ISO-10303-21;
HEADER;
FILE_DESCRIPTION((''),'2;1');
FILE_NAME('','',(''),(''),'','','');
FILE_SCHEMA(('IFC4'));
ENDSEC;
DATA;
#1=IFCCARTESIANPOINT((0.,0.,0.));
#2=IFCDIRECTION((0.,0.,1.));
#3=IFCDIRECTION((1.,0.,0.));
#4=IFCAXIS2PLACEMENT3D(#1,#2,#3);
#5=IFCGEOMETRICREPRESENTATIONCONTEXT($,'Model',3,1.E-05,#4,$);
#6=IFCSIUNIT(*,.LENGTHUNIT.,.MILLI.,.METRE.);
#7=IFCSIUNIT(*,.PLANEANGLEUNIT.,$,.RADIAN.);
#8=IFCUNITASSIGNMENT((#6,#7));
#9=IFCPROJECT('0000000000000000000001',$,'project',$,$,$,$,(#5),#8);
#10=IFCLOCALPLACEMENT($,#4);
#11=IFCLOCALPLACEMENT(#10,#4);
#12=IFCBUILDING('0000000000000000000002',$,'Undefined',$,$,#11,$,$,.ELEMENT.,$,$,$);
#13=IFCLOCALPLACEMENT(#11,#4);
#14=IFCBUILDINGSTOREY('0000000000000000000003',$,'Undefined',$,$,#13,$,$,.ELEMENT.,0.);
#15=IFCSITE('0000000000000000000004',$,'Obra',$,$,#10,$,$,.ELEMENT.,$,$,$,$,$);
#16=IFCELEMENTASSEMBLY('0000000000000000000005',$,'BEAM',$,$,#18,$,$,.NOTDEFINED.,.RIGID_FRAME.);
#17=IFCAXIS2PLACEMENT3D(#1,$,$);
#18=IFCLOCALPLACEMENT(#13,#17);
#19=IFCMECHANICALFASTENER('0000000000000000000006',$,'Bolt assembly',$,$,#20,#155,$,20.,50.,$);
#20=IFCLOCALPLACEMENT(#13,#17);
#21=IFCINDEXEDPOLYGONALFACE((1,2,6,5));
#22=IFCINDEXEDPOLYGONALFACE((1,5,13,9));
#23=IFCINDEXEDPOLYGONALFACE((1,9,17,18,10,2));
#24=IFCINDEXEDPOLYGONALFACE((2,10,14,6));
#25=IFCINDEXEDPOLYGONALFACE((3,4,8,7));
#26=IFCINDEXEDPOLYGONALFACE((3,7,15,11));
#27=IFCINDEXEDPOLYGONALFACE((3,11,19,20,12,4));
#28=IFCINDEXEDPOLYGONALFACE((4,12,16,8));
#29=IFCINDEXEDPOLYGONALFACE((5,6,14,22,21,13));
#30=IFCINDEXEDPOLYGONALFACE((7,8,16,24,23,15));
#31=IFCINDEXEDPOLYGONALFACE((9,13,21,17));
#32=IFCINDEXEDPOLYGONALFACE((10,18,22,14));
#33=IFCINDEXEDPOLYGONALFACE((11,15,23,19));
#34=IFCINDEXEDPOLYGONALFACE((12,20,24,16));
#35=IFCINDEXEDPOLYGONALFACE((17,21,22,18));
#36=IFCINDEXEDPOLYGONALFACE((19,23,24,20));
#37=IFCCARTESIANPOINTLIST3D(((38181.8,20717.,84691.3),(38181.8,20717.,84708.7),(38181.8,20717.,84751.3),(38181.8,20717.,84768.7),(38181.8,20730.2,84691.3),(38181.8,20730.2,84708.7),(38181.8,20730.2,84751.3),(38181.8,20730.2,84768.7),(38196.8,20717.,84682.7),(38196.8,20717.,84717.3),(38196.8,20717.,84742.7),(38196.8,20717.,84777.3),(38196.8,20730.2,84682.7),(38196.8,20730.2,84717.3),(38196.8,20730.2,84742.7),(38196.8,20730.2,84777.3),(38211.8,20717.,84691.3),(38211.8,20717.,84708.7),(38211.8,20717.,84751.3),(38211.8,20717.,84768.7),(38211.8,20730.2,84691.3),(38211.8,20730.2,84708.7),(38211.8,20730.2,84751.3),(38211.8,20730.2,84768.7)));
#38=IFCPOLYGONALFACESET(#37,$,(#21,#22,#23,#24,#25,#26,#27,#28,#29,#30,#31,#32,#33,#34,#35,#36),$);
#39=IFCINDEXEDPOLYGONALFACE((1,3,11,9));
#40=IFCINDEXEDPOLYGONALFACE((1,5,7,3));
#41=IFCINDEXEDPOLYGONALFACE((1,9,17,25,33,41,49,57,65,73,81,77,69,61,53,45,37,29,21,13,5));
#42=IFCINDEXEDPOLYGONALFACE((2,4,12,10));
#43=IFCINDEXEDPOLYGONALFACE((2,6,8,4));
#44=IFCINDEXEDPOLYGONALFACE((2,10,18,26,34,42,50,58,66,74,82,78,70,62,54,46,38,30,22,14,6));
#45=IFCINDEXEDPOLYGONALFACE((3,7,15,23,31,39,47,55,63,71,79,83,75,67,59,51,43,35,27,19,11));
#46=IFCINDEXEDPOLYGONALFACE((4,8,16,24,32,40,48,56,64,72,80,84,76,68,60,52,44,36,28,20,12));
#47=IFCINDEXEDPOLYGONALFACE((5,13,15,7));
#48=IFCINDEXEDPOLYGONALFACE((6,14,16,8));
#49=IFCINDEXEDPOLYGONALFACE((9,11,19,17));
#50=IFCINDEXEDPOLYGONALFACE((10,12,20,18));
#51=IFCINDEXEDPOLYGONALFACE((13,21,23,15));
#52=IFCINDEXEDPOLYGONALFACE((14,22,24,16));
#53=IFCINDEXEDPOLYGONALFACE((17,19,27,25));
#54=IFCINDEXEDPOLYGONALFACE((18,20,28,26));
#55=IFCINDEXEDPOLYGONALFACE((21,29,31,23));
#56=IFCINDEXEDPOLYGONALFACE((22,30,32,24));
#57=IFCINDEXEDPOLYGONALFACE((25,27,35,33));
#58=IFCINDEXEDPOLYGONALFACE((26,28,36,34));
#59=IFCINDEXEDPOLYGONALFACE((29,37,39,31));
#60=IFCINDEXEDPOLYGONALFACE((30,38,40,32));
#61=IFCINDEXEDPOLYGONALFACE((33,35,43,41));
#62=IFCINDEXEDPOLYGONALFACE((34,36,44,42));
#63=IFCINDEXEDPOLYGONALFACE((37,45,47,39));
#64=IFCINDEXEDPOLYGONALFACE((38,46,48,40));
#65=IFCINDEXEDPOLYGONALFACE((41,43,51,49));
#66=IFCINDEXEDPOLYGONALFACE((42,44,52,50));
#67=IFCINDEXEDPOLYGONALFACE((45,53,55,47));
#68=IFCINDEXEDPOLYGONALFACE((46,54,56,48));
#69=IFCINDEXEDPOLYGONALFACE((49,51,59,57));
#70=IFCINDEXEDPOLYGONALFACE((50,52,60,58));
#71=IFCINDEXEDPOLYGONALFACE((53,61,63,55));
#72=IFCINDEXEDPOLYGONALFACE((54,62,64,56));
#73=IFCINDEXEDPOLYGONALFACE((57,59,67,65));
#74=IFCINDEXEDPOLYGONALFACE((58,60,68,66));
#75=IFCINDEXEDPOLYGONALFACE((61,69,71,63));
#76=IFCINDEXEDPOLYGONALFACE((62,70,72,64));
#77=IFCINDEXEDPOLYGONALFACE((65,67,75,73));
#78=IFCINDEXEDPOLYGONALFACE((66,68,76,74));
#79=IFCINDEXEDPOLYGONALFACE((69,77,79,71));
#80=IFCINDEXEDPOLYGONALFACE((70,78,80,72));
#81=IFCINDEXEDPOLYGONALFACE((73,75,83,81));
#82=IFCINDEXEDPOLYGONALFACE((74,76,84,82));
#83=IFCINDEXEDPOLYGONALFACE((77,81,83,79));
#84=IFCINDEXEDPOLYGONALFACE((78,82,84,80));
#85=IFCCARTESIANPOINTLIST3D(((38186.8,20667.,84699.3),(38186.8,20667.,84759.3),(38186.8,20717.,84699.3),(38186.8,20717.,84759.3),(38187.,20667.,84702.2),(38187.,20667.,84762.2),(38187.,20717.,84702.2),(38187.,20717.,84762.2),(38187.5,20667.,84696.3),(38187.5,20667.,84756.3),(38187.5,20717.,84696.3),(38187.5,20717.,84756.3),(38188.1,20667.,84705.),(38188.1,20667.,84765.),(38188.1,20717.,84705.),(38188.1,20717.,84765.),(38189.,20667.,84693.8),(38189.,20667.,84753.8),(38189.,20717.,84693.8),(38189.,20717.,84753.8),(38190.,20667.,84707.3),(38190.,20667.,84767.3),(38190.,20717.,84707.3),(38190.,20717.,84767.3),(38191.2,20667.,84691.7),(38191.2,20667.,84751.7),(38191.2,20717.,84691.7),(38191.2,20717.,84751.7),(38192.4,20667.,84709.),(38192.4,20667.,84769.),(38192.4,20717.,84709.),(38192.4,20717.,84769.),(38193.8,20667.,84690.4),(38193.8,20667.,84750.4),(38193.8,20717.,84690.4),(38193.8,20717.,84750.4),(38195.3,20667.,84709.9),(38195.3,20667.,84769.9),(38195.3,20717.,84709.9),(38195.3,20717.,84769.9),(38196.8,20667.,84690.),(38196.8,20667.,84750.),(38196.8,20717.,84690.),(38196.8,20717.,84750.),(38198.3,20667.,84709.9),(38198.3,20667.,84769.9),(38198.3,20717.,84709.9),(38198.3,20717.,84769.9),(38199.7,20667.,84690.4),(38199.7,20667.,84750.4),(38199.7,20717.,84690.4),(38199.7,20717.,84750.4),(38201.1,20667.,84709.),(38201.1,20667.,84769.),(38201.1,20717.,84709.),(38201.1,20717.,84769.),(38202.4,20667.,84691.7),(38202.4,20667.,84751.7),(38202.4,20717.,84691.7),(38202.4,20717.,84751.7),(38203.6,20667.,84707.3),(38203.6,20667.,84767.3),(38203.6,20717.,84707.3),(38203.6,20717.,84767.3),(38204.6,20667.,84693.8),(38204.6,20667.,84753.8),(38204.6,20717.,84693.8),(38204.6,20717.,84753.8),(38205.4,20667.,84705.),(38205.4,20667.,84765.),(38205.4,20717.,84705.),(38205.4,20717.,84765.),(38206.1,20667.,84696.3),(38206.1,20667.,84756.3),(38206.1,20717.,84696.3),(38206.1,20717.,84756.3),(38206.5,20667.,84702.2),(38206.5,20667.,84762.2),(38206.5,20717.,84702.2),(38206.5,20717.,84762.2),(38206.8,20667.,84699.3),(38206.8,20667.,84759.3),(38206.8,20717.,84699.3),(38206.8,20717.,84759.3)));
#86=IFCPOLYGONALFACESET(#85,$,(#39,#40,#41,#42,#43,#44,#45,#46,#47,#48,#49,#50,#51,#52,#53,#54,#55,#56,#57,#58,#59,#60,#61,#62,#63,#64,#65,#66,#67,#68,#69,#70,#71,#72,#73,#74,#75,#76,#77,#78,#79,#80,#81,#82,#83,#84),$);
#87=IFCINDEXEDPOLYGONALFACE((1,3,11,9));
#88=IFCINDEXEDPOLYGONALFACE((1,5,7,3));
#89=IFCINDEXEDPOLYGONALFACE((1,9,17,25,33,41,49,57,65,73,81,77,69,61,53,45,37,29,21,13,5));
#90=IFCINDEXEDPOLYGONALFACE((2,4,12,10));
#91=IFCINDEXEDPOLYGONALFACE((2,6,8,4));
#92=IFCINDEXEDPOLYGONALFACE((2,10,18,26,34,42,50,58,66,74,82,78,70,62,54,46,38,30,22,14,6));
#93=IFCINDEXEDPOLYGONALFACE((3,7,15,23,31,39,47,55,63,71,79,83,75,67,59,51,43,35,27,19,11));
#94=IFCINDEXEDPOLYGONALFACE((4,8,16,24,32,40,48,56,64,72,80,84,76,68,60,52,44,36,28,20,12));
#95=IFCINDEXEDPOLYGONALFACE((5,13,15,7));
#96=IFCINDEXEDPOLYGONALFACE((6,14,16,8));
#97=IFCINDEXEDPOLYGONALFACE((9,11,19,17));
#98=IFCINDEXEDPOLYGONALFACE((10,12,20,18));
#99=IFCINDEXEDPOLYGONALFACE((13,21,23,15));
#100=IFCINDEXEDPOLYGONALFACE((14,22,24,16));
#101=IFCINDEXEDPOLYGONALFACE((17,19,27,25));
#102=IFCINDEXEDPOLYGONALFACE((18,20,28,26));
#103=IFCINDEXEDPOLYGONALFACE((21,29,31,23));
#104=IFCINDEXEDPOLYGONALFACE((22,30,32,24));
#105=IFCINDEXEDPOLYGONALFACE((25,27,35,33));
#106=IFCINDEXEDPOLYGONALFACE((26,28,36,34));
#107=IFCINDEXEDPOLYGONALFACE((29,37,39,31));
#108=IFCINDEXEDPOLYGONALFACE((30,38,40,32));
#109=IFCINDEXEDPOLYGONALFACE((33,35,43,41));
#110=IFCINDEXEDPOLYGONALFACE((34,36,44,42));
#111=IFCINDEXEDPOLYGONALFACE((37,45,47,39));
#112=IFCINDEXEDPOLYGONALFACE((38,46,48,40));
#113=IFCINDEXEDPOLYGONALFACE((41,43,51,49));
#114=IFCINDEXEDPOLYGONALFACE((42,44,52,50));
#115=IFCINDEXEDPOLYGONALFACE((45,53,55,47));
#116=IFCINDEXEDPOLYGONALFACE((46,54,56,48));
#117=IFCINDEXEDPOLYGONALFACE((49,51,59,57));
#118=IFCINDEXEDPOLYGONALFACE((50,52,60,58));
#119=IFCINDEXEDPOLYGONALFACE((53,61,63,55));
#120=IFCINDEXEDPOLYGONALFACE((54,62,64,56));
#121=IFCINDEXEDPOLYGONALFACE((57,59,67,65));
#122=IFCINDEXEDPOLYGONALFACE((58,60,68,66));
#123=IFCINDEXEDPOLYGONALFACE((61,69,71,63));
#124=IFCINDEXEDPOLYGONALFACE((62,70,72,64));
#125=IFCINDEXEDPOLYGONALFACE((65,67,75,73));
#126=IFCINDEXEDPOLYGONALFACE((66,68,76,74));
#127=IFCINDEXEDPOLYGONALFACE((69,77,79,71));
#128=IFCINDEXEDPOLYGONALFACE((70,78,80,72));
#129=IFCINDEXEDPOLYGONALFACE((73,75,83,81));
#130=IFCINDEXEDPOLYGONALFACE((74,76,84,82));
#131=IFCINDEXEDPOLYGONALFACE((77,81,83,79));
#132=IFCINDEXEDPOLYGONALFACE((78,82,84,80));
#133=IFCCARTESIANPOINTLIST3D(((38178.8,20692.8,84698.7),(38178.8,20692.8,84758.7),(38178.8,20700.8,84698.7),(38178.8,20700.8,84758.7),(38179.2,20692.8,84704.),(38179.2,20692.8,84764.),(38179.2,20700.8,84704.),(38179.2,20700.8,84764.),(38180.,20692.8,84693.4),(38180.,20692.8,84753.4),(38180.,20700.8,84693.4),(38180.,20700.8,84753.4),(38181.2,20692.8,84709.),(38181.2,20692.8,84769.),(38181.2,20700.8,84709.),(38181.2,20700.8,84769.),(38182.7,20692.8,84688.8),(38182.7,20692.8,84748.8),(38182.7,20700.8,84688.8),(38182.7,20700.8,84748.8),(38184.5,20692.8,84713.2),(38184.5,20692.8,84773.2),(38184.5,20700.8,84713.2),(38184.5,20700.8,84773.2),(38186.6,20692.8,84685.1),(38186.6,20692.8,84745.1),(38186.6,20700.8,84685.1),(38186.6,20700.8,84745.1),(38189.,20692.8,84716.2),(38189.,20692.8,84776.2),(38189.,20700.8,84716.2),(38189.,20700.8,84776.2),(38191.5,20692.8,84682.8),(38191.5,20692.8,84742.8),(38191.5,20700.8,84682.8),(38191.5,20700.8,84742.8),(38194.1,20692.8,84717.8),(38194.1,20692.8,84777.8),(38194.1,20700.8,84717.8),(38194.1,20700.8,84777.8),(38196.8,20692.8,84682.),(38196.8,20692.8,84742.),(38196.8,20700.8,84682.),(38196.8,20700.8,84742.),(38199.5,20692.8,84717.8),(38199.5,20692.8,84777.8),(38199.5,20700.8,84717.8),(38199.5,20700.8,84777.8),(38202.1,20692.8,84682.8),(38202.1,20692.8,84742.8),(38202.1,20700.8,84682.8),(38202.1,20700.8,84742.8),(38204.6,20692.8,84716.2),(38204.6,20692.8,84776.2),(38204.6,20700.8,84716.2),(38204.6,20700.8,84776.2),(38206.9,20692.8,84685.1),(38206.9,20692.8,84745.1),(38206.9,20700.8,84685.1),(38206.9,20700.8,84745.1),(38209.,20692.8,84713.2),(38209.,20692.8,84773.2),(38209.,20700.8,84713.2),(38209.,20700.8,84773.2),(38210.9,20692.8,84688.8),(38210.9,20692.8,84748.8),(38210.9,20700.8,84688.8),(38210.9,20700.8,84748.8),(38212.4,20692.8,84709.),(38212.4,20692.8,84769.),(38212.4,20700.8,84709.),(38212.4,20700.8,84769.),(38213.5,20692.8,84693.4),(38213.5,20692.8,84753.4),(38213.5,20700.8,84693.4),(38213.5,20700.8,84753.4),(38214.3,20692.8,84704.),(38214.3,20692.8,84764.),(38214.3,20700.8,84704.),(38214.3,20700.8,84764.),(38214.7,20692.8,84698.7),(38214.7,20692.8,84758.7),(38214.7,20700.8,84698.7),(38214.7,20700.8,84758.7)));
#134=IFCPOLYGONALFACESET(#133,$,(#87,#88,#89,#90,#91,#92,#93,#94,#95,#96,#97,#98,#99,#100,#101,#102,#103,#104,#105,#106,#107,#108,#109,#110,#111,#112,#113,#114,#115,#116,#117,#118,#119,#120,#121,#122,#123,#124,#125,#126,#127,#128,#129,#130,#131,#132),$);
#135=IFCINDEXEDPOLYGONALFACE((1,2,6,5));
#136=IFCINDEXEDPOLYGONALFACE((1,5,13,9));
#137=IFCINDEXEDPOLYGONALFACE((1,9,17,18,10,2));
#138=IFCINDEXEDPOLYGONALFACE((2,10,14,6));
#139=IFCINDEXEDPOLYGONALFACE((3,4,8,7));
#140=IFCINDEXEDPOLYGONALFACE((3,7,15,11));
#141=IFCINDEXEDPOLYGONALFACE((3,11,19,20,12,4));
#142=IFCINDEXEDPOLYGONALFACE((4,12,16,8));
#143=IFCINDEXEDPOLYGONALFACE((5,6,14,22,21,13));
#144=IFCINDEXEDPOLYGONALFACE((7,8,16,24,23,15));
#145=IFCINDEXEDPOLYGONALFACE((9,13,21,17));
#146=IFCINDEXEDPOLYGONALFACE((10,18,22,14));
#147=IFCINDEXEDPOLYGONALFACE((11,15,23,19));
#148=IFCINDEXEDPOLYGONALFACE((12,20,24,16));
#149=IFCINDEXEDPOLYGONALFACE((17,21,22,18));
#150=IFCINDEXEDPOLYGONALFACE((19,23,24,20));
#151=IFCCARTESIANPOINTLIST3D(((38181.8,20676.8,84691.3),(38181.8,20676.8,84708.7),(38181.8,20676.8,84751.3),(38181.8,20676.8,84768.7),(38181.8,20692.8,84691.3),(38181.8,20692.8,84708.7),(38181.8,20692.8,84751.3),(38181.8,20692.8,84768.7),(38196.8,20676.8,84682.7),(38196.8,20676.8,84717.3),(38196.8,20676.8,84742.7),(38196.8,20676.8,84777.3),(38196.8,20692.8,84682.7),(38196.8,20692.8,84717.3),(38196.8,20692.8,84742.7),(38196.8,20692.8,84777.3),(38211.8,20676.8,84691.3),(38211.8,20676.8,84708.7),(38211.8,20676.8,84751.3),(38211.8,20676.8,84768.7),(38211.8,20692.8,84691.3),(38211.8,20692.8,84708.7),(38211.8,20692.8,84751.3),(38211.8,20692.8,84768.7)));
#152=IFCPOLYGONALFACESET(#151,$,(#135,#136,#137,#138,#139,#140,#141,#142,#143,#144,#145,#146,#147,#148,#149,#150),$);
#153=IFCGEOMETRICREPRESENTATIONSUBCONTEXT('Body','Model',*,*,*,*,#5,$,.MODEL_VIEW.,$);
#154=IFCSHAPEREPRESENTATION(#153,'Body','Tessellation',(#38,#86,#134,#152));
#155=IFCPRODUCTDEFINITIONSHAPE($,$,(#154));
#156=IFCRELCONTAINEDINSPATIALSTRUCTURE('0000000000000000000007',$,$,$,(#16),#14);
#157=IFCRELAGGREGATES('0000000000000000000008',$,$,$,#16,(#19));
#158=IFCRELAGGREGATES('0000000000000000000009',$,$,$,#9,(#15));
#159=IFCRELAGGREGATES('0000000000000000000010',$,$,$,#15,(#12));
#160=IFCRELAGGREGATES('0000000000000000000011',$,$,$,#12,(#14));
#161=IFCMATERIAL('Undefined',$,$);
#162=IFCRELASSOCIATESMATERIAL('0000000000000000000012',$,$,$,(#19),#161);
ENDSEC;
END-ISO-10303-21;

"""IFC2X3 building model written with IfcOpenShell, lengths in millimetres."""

from ifc_helpers import new_model, si_unit, frame, origin_with_axes, origin_2d_with_axis, place, context, subcontext, project, spatial, polyline, circle, outline, extrude, source, transform, mapped, material, element, aggregate, save


model = new_model("IFC2X3")

# Units and contexts
model_context = context("Model", 3, precision=1e-05, world=origin_with_axes())
body_context = subcontext(model_context, "Body", "Model", "MODEL_VIEW")
ifc_project = project(units=[si_unit("LENGTHUNIT", "METRE", prefix="MILLI"), si_unit("PLANEANGLEUNIT", "RADIAN")], contexts=[model_context])

# Site, building, storey
site_placement = place(None, origin_with_axes())
site = spatial("IfcSite", under=ifc_project, at=site_placement, Name="Obra", CompositionType="ELEMENT")
building_placement = place(site_placement, origin_with_axes())
building = spatial("IfcBuilding", under=site, at=building_placement, Name="Undefined", CompositionType="ELEMENT")
storey_placement = place(building_placement, origin_with_axes())
storey = spatial("IfcBuildingStorey", under=building, at=storey_placement, Name="Undefined", CompositionType="ELEMENT", Elevation=0.0)

# Shared definitions
ifc_material_1 = material(Name="Undefined")

# Element assembly, mechanical fastener
assembly_1_placement = place(storey_placement, origin_with_axes())
assembly_1 = element("IfcElementAssembly", 1, at=assembly_1_placement, inside=storey, Name="BEAM", AssemblyPlace="NOTDEFINED", PredefinedType="RIGID_FRAME")
shared_shape_1 = source(origin_with_axes(), body_context, "Body", "SweptSolid", [
    extrude(outline(polyline([(17.3, 0.0), (8.7, 15.0), (-8.7, 15.0), (-17.3, 0.0), (-8.7, -15.0), (8.7, -15.0), (17.3, 0.0)])), frame((0.0, -26.3, 0.0), z_axis=(0.0, 1.0, 0.0), x_axis=(1.0, 0.0, 0.0)), (0.0, 0.0, 1.0), 13.2),
    extrude(circle(Radius=10.0, at=origin_2d_with_axis()), frame((0.0, -13.1, 0.0), z_axis=(0.0, 1.0, 0.0), x_axis=(1.0, 0.0, 0.0)), (0.0, 0.0, 1.0), 50.0),
    extrude(circle(Radius=18.0, at=origin_2d_with_axis()), frame((0.0, 3.1, 0.0), z_axis=(0.0, 1.0, 0.0), x_axis=(1.0, 0.0, 0.0)), (0.0, 0.0, 1.0), 8.0),
    extrude(outline(polyline([(17.3, 0.0), (8.7, 15.0), (-8.7, 15.0), (-17.3, 0.0), (-8.7, -15.0), (8.7, -15.0), (17.3, 0.0)])), frame((0.0, 11.1, 0.0), z_axis=(0.0, 1.0, 0.0), x_axis=(1.0, 0.0, 0.0)), (0.0, 0.0, 1.0), 16.0),
])
mechanical_fastener_1_placement = place(assembly_1_placement, frame((38236.8, 20703.9, 84850.0), z_axis=(-1.0, 0.0, 0.0), x_axis=(0.0, 0.0, -1.0)))
mechanical_fastener_1 = element("IfcMechanicalFastener", 2, at=mechanical_fastener_1_placement, material=ifc_material_1, Name="Bolt assembly", NominalDiameter=20.0, NominalLength=50.0, context=body_context, shape_type="MappedRepresentation", body=[
    mapped(shared_shape_1, transform((90.0, 0.0, 40.0))),
    mapped(shared_shape_1, transform((150.0, 0.0, 40.0))),
])
aggregate(assembly_1, [mechanical_fastener_1])

save(model, "model.ifc")
